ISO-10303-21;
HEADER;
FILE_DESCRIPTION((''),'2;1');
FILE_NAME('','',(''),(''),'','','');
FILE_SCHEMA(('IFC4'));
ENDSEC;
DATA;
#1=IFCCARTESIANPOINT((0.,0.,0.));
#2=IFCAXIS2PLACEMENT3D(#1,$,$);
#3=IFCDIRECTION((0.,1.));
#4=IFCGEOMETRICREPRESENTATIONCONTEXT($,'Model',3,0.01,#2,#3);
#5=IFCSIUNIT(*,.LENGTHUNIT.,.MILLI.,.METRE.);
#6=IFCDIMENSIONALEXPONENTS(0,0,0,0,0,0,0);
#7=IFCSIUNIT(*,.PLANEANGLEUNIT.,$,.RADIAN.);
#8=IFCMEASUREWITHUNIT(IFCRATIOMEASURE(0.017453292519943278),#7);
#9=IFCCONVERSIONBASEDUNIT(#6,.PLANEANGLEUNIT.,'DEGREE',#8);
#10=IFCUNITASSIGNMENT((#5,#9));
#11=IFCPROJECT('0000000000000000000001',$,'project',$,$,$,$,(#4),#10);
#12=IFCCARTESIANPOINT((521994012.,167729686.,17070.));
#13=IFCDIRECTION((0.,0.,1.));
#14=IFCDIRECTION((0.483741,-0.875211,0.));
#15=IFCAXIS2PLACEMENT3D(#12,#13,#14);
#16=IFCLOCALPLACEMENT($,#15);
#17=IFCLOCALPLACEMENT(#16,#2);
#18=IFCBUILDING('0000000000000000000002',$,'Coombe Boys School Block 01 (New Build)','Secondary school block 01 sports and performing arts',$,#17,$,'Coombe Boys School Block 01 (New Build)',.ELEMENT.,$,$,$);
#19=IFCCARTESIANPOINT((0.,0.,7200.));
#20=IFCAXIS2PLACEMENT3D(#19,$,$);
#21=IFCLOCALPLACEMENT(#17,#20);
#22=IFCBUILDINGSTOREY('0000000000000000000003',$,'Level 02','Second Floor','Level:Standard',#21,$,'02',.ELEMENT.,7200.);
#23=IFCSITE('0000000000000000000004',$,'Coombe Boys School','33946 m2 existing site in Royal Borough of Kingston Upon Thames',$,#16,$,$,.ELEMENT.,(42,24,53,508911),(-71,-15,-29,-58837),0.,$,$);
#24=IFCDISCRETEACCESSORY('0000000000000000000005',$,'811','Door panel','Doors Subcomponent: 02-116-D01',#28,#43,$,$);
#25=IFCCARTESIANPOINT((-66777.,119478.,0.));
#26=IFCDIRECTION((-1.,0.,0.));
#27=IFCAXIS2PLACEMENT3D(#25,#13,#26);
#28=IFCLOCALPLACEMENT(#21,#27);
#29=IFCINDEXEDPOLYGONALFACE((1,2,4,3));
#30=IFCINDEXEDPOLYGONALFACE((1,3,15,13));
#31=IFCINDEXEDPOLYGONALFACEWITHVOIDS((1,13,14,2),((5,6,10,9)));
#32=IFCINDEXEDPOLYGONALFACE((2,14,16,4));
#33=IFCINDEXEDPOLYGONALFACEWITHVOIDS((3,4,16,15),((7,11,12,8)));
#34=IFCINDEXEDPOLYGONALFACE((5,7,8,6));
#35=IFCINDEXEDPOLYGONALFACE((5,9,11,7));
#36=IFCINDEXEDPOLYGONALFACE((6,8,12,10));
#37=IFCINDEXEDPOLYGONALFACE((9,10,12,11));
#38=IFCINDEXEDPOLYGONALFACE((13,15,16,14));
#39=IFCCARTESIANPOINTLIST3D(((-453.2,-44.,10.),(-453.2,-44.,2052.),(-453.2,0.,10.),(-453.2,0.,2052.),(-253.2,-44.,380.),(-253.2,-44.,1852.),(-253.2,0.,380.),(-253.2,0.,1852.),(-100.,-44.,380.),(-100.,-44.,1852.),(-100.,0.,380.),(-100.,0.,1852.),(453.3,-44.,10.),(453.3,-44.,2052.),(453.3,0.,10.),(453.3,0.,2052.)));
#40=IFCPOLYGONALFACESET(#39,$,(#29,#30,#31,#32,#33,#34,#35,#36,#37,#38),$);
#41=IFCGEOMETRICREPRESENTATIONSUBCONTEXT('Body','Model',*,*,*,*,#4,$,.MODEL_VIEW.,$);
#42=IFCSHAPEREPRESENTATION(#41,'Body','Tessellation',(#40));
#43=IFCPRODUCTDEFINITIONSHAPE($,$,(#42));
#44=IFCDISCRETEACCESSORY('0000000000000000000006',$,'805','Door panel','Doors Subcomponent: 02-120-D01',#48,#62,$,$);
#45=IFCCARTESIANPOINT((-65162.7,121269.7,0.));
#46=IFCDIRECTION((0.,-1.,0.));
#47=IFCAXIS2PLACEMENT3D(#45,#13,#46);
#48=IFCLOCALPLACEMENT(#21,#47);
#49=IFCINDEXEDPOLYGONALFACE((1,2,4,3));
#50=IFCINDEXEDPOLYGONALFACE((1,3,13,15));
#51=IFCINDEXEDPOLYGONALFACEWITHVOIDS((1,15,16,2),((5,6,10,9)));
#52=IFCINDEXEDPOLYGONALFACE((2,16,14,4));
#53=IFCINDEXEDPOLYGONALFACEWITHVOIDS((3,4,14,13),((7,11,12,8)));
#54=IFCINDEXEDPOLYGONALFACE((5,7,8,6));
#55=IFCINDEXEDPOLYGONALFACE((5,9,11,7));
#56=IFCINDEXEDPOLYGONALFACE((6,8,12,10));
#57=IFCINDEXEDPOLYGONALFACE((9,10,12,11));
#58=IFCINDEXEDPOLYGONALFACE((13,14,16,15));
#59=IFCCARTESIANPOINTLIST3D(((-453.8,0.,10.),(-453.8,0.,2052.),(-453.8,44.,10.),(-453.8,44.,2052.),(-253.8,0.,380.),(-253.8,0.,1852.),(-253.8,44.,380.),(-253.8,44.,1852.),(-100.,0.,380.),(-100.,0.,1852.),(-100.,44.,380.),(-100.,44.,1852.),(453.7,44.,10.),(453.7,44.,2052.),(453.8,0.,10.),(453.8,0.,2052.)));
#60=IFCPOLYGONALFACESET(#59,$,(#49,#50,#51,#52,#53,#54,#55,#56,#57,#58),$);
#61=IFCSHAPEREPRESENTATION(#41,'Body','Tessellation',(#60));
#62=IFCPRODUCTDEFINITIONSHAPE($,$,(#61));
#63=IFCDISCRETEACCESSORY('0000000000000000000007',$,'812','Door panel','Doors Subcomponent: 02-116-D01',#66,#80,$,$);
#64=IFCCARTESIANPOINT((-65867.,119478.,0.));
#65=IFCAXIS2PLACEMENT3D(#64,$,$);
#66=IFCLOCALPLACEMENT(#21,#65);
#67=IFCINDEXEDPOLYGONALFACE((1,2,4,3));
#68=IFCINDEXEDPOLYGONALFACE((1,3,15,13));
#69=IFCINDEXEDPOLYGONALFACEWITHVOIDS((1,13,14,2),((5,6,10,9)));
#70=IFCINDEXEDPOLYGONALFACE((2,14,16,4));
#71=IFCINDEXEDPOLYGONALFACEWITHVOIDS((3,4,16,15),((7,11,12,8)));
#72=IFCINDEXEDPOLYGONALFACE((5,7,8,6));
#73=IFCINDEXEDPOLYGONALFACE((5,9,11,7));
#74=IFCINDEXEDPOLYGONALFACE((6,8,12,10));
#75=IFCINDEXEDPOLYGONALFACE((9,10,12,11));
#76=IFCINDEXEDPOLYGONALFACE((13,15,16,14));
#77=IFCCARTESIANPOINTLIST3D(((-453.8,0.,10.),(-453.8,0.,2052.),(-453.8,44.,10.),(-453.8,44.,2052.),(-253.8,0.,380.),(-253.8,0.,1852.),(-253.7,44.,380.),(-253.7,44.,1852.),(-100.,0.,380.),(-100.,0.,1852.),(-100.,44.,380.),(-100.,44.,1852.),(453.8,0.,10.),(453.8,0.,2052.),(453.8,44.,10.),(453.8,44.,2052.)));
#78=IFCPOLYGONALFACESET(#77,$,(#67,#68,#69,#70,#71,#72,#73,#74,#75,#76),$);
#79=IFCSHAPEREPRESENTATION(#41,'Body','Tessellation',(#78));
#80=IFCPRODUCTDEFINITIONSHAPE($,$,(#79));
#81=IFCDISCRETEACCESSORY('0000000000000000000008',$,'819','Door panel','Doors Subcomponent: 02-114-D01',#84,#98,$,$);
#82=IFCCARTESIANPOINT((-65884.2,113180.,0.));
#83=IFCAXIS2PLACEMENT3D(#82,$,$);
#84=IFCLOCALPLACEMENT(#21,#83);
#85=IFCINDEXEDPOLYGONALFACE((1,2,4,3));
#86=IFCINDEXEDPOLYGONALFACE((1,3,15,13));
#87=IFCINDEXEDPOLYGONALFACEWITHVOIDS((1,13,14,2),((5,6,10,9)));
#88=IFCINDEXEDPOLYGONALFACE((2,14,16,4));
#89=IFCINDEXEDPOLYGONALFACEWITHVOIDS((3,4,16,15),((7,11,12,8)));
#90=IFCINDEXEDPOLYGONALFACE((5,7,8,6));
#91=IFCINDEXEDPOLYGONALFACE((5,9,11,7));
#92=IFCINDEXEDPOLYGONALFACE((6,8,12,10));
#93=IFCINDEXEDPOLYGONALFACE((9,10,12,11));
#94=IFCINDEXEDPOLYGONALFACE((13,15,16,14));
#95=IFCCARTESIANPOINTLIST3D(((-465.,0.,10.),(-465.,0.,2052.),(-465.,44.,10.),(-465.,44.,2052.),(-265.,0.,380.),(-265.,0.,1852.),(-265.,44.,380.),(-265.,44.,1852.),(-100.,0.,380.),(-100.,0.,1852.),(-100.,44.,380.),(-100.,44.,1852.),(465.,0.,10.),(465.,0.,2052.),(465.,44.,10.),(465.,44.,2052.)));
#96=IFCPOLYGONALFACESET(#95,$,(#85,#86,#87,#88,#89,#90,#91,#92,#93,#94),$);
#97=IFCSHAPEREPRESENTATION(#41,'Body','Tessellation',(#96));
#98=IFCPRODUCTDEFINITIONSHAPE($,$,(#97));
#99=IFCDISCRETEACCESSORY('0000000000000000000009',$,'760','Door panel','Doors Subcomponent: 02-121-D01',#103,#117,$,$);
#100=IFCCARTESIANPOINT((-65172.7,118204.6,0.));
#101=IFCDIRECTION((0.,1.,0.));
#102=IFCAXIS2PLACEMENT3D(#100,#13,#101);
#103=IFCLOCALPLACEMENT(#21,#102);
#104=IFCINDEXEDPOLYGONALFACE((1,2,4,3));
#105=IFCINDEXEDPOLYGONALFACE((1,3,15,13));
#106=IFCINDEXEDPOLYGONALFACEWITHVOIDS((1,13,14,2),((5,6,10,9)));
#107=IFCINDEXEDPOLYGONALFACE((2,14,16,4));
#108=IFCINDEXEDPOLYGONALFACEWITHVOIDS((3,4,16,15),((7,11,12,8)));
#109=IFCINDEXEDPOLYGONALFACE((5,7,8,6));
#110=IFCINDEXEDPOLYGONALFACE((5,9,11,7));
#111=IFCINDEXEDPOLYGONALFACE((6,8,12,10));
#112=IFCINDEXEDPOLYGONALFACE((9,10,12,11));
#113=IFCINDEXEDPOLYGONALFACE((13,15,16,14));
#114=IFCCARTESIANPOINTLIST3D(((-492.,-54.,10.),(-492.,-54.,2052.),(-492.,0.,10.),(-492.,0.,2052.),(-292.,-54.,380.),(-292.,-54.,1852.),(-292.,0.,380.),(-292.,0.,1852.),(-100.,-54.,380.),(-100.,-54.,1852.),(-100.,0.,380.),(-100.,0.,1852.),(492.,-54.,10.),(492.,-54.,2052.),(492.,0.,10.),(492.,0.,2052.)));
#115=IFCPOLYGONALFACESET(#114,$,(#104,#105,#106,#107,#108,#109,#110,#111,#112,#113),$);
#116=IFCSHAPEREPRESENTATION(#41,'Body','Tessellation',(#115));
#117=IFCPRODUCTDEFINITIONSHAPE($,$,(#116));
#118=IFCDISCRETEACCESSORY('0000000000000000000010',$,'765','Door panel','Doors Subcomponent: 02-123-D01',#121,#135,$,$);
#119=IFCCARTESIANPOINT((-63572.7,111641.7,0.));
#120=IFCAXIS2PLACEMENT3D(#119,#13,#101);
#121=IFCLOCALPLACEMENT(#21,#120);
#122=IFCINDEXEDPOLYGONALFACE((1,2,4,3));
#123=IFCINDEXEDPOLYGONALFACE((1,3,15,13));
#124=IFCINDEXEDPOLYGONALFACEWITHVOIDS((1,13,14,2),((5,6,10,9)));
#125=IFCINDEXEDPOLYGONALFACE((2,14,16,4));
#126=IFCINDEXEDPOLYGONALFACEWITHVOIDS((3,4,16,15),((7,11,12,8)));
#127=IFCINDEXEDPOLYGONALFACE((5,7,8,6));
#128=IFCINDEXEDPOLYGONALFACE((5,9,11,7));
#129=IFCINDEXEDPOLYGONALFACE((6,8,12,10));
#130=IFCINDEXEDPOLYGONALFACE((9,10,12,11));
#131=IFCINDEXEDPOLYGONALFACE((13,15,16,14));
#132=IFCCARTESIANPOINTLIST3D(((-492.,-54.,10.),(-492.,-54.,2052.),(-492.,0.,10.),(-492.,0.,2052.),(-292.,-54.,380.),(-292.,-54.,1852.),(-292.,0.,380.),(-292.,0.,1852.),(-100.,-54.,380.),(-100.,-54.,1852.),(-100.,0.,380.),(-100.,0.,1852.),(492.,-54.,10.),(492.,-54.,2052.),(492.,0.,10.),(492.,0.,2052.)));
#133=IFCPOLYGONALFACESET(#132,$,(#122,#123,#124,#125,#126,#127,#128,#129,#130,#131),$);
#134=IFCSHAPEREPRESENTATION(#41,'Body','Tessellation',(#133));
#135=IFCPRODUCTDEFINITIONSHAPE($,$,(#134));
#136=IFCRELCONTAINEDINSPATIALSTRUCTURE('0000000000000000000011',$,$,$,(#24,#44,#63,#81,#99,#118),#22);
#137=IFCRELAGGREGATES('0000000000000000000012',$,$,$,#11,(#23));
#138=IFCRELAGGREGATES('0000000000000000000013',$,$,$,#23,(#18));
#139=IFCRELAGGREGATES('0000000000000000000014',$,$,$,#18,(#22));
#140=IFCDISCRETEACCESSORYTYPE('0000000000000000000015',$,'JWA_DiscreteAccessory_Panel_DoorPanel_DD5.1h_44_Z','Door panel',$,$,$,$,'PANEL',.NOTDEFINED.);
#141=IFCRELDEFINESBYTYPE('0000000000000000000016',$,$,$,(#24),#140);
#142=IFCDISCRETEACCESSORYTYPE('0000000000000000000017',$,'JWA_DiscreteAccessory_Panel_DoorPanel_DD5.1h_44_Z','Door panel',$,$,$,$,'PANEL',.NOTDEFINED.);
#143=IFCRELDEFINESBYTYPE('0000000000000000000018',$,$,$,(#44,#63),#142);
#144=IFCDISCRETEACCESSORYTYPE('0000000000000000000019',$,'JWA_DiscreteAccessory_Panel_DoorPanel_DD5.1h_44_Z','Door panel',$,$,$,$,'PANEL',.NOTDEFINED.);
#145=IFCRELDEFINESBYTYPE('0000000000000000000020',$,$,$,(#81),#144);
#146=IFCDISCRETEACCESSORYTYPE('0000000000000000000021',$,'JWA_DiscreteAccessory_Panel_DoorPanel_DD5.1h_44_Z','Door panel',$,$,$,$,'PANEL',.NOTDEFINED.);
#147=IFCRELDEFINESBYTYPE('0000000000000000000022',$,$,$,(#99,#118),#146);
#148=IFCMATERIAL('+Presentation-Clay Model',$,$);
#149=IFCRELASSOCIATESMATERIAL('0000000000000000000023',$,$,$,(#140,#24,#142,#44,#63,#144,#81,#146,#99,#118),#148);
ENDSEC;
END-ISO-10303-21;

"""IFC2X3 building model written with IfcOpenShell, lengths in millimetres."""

from ifc_helpers import new_model, entity, si_unit, converted_unit, direction, frame, origin, place, context, subcontext, project, spatial, polyline, outline, extrude, source, transform, mapped, material, type_object, type_shapes, element, save


model = new_model("IFC2X3")

# Units and contexts
model_context = context("Model", 3, precision=0.01, world=origin(), true_north=direction((0.0, 1.0)))
body_context = subcontext(model_context, "Body", "Model", "MODEL_VIEW")
ifc_project = project(units=[si_unit("LENGTHUNIT", "METRE", prefix="MILLI"), converted_unit("PLANEANGLEUNIT", "DEGREE", entity("IfcRatioMeasure", 0.017453292519943278), si_unit("PLANEANGLEUNIT", "RADIAN"), dimensions=[0, 0, 0, 0, 0, 0, 0])], contexts=[model_context])

# Site, building, storey
site_placement = place(None, frame((521994012.0, 167729686.0, 17070.0), z_axis=(0.0, 0.0, 1.0), x_axis=(0.483741, -0.875211, 0.0)))
site = spatial("IfcSite", under=ifc_project, at=site_placement, Name="Coombe Boys School", Description="33946 m2 existing site in Royal Borough of Kingston Upon Thames", CompositionType="ELEMENT", RefLatitude=(42, 24, 53, 508911), RefLongitude=(-71, -15, -29, -58837), RefElevation=0.0)
building_placement = place(site_placement, origin())
building = spatial("IfcBuilding", under=site, at=building_placement, Name="Coombe Boys School Block 01 (New Build)", Description="Secondary school block 01 sports and performing arts", LongName="Coombe Boys School Block 01 (New Build)", CompositionType="ELEMENT")
storey_placement = place(building_placement, frame((0.0, 0.0, 7200.0)))
storey = spatial("IfcBuildingStorey", under=building, at=storey_placement, Name="Level 02", Description="Second Floor", ObjectType="Level:Standard", LongName="02", CompositionType="ELEMENT", Elevation=7200.0)

# Discrete accessories
ifc_material_1 = material(Name="+Presentation-Clay Model")
discrete_accessory_type_1 = type_object("IfcDiscreteAccessoryType", Name="JWA_DiscreteAccessory_Panel_DoorPanel_DD5.1h_44_Z", Description="Door panel", ElementType="PANEL", material=ifc_material_1)
shared_shape_1 = source(origin(), body_context, "Body", "SweptSolid", [
    extrude(outline(polyline([(-1021.0, -453.3), (1021.0, -453.3), (1021.0, 453.3), (-1021.0, 453.3), (-1021.0, -453.3)]), holes=[polyline([(-821.0, 100.0), (-821.0, 253.2), (651.0, 253.2), (651.0, 100.0), (-821.0, 100.0)])]), frame((0.0, -44.0, 1031.0), z_axis=(0.0, 1.0, 0.0), x_axis=(0.0, 0.0, -1.0)), (0.0, 0.0, 1.0), 44.0),
])
type_shapes(discrete_accessory_type_1, [shared_shape_1])
discrete_accessory_1_placement = place(storey_placement, frame((-66777.0, 119478.0, 0.0), z_axis=(0.0, 0.0, 1.0), x_axis=(-1.0, 0.0, 0.0)))
element("IfcDiscreteAccessory", 1, at=discrete_accessory_1_placement, inside=storey, type_object=discrete_accessory_type_1, material=ifc_material_1, Name="811", Description="Door panel", ObjectType="Doors Subcomponent: 02-116-D01", context=body_context, shape_type="MappedRepresentation", body=[
    mapped(shared_shape_1, transform((0.0, 0.0, 0.0), scale=1.0)),
])
discrete_accessory_type_2 = type_object("IfcDiscreteAccessoryType", Name="JWA_DiscreteAccessory_Panel_DoorPanel_DD5.1h_44_Z", Description="Door panel", ElementType="PANEL", material=ifc_material_1)
shared_shape_2 = source(origin(), body_context, "Body", "SweptSolid", [
    extrude(outline(polyline([(-1021.0, -453.7), (1021.0, -453.7), (1021.0, 453.7), (-1021.0, 453.7), (-1021.0, -453.7)]), holes=[polyline([(-821.0, 100.0), (-821.0, 253.7), (651.0, 253.7), (651.0, 100.0), (-821.0, 100.0)])]), frame((0.0, 0.0, 1031.0), z_axis=(0.0, 1.0, 0.0), x_axis=(0.0, 0.0, -1.0)), (0.0, 0.0, 1.0), 44.0),
])
type_shapes(discrete_accessory_type_2, [shared_shape_2])
discrete_accessory_2_placement = place(storey_placement, frame((-65162.7, 121269.7, 0.0), z_axis=(0.0, 0.0, 1.0), x_axis=(0.0, -1.0, 0.0)))
element("IfcDiscreteAccessory", 2, at=discrete_accessory_2_placement, inside=storey, type_object=discrete_accessory_type_2, material=ifc_material_1, Name="805", Description="Door panel", ObjectType="Doors Subcomponent: 02-120-D01", context=body_context, shape_type="MappedRepresentation", body=[
    mapped(shared_shape_2, transform((0.0, 0.0, 0.0), scale=1.0)),
])
discrete_accessory_3_placement = place(storey_placement, frame((-65867.0, 119478.0, 0.0)))
element("IfcDiscreteAccessory", 3, at=discrete_accessory_3_placement, inside=storey, type_object=discrete_accessory_type_2, material=ifc_material_1, Name="812", Description="Door panel", ObjectType="Doors Subcomponent: 02-116-D01", context=body_context, shape_type="MappedRepresentation", body=[
    mapped(shared_shape_2, transform((0.0, 0.0, 0.0), scale=1.0)),
])

# Discrete accessory
discrete_accessory_type_3 = type_object("IfcDiscreteAccessoryType", Name="JWA_DiscreteAccessory_Panel_DoorPanel_DD5.1h_44_Z", Description="Door panel", ElementType="PANEL", material=ifc_material_1)
shared_shape_3 = source(origin(), body_context, "Body", "SweptSolid", [
    extrude(outline(polyline([(-1021.0, -465.0), (1021.0, -465.0), (1021.0, 465.0), (-1021.0, 465.0), (-1021.0, -465.0)]), holes=[polyline([(-821.0, 100.0), (-821.0, 265.0), (651.0, 265.0), (651.0, 100.0), (-821.0, 100.0)])]), frame((0.0, 0.0, 1031.0), z_axis=(0.0, 1.0, 0.0), x_axis=(0.0, 0.0, -1.0)), (0.0, 0.0, 1.0), 44.0),
])
type_shapes(discrete_accessory_type_3, [shared_shape_3])
discrete_accessory_4_placement = place(storey_placement, frame((-65884.2, 113180.0, 0.0)))
element("IfcDiscreteAccessory", 4, at=discrete_accessory_4_placement, inside=storey, type_object=discrete_accessory_type_3, material=ifc_material_1, Name="819", Description="Door panel", ObjectType="Doors Subcomponent: 02-114-D01", context=body_context, shape_type="MappedRepresentation", body=[
    mapped(shared_shape_3, transform((0.0, 0.0, 0.0), scale=1.0)),
])

# Discrete accessories
discrete_accessory_type_4 = type_object("IfcDiscreteAccessoryType", Name="JWA_DiscreteAccessory_Panel_DoorPanel_DD5.1h_44_Z", Description="Door panel", ElementType="PANEL", material=ifc_material_1)
shared_shape_4 = source(origin(), body_context, "Body", "SweptSolid", [
    extrude(outline(polyline([(-1021.0, -492.0), (1021.0, -492.0), (1021.0, 492.0), (-1021.0, 492.0), (-1021.0, -492.0)]), holes=[polyline([(-821.0, 100.0), (-821.0, 292.0), (651.0, 292.0), (651.0, 100.0), (-821.0, 100.0)])]), frame((0.0, -54.0, 1031.0), z_axis=(0.0, 1.0, 0.0), x_axis=(0.0, 0.0, -1.0)), (0.0, 0.0, 1.0), 54.0),
])
type_shapes(discrete_accessory_type_4, [shared_shape_4])
discrete_accessory_5_placement = place(storey_placement, frame((-65172.7, 118204.6, 0.0), z_axis=(0.0, 0.0, 1.0), x_axis=(0.0, 1.0, 0.0)))
element("IfcDiscreteAccessory", 5, at=discrete_accessory_5_placement, inside=storey, type_object=discrete_accessory_type_4, material=ifc_material_1, Name="760", Description="Door panel", ObjectType="Doors Subcomponent: 02-121-D01", context=body_context, shape_type="MappedRepresentation", body=[
    mapped(shared_shape_4, transform((0.0, 0.0, 0.0), scale=1.0)),
])
discrete_accessory_6_placement = place(storey_placement, frame((-63572.7, 111641.7, 0.0), z_axis=(0.0, 0.0, 1.0), x_axis=(0.0, 1.0, 0.0)))
element("IfcDiscreteAccessory", 6, at=discrete_accessory_6_placement, inside=storey, type_object=discrete_accessory_type_4, material=ifc_material_1, Name="765", Description="Door panel", ObjectType="Doors Subcomponent: 02-123-D01", context=body_context, shape_type="MappedRepresentation", body=[
    mapped(shared_shape_4, transform((0.0, 0.0, 0.0), scale=1.0)),
])

save(model, "model.ifc")
